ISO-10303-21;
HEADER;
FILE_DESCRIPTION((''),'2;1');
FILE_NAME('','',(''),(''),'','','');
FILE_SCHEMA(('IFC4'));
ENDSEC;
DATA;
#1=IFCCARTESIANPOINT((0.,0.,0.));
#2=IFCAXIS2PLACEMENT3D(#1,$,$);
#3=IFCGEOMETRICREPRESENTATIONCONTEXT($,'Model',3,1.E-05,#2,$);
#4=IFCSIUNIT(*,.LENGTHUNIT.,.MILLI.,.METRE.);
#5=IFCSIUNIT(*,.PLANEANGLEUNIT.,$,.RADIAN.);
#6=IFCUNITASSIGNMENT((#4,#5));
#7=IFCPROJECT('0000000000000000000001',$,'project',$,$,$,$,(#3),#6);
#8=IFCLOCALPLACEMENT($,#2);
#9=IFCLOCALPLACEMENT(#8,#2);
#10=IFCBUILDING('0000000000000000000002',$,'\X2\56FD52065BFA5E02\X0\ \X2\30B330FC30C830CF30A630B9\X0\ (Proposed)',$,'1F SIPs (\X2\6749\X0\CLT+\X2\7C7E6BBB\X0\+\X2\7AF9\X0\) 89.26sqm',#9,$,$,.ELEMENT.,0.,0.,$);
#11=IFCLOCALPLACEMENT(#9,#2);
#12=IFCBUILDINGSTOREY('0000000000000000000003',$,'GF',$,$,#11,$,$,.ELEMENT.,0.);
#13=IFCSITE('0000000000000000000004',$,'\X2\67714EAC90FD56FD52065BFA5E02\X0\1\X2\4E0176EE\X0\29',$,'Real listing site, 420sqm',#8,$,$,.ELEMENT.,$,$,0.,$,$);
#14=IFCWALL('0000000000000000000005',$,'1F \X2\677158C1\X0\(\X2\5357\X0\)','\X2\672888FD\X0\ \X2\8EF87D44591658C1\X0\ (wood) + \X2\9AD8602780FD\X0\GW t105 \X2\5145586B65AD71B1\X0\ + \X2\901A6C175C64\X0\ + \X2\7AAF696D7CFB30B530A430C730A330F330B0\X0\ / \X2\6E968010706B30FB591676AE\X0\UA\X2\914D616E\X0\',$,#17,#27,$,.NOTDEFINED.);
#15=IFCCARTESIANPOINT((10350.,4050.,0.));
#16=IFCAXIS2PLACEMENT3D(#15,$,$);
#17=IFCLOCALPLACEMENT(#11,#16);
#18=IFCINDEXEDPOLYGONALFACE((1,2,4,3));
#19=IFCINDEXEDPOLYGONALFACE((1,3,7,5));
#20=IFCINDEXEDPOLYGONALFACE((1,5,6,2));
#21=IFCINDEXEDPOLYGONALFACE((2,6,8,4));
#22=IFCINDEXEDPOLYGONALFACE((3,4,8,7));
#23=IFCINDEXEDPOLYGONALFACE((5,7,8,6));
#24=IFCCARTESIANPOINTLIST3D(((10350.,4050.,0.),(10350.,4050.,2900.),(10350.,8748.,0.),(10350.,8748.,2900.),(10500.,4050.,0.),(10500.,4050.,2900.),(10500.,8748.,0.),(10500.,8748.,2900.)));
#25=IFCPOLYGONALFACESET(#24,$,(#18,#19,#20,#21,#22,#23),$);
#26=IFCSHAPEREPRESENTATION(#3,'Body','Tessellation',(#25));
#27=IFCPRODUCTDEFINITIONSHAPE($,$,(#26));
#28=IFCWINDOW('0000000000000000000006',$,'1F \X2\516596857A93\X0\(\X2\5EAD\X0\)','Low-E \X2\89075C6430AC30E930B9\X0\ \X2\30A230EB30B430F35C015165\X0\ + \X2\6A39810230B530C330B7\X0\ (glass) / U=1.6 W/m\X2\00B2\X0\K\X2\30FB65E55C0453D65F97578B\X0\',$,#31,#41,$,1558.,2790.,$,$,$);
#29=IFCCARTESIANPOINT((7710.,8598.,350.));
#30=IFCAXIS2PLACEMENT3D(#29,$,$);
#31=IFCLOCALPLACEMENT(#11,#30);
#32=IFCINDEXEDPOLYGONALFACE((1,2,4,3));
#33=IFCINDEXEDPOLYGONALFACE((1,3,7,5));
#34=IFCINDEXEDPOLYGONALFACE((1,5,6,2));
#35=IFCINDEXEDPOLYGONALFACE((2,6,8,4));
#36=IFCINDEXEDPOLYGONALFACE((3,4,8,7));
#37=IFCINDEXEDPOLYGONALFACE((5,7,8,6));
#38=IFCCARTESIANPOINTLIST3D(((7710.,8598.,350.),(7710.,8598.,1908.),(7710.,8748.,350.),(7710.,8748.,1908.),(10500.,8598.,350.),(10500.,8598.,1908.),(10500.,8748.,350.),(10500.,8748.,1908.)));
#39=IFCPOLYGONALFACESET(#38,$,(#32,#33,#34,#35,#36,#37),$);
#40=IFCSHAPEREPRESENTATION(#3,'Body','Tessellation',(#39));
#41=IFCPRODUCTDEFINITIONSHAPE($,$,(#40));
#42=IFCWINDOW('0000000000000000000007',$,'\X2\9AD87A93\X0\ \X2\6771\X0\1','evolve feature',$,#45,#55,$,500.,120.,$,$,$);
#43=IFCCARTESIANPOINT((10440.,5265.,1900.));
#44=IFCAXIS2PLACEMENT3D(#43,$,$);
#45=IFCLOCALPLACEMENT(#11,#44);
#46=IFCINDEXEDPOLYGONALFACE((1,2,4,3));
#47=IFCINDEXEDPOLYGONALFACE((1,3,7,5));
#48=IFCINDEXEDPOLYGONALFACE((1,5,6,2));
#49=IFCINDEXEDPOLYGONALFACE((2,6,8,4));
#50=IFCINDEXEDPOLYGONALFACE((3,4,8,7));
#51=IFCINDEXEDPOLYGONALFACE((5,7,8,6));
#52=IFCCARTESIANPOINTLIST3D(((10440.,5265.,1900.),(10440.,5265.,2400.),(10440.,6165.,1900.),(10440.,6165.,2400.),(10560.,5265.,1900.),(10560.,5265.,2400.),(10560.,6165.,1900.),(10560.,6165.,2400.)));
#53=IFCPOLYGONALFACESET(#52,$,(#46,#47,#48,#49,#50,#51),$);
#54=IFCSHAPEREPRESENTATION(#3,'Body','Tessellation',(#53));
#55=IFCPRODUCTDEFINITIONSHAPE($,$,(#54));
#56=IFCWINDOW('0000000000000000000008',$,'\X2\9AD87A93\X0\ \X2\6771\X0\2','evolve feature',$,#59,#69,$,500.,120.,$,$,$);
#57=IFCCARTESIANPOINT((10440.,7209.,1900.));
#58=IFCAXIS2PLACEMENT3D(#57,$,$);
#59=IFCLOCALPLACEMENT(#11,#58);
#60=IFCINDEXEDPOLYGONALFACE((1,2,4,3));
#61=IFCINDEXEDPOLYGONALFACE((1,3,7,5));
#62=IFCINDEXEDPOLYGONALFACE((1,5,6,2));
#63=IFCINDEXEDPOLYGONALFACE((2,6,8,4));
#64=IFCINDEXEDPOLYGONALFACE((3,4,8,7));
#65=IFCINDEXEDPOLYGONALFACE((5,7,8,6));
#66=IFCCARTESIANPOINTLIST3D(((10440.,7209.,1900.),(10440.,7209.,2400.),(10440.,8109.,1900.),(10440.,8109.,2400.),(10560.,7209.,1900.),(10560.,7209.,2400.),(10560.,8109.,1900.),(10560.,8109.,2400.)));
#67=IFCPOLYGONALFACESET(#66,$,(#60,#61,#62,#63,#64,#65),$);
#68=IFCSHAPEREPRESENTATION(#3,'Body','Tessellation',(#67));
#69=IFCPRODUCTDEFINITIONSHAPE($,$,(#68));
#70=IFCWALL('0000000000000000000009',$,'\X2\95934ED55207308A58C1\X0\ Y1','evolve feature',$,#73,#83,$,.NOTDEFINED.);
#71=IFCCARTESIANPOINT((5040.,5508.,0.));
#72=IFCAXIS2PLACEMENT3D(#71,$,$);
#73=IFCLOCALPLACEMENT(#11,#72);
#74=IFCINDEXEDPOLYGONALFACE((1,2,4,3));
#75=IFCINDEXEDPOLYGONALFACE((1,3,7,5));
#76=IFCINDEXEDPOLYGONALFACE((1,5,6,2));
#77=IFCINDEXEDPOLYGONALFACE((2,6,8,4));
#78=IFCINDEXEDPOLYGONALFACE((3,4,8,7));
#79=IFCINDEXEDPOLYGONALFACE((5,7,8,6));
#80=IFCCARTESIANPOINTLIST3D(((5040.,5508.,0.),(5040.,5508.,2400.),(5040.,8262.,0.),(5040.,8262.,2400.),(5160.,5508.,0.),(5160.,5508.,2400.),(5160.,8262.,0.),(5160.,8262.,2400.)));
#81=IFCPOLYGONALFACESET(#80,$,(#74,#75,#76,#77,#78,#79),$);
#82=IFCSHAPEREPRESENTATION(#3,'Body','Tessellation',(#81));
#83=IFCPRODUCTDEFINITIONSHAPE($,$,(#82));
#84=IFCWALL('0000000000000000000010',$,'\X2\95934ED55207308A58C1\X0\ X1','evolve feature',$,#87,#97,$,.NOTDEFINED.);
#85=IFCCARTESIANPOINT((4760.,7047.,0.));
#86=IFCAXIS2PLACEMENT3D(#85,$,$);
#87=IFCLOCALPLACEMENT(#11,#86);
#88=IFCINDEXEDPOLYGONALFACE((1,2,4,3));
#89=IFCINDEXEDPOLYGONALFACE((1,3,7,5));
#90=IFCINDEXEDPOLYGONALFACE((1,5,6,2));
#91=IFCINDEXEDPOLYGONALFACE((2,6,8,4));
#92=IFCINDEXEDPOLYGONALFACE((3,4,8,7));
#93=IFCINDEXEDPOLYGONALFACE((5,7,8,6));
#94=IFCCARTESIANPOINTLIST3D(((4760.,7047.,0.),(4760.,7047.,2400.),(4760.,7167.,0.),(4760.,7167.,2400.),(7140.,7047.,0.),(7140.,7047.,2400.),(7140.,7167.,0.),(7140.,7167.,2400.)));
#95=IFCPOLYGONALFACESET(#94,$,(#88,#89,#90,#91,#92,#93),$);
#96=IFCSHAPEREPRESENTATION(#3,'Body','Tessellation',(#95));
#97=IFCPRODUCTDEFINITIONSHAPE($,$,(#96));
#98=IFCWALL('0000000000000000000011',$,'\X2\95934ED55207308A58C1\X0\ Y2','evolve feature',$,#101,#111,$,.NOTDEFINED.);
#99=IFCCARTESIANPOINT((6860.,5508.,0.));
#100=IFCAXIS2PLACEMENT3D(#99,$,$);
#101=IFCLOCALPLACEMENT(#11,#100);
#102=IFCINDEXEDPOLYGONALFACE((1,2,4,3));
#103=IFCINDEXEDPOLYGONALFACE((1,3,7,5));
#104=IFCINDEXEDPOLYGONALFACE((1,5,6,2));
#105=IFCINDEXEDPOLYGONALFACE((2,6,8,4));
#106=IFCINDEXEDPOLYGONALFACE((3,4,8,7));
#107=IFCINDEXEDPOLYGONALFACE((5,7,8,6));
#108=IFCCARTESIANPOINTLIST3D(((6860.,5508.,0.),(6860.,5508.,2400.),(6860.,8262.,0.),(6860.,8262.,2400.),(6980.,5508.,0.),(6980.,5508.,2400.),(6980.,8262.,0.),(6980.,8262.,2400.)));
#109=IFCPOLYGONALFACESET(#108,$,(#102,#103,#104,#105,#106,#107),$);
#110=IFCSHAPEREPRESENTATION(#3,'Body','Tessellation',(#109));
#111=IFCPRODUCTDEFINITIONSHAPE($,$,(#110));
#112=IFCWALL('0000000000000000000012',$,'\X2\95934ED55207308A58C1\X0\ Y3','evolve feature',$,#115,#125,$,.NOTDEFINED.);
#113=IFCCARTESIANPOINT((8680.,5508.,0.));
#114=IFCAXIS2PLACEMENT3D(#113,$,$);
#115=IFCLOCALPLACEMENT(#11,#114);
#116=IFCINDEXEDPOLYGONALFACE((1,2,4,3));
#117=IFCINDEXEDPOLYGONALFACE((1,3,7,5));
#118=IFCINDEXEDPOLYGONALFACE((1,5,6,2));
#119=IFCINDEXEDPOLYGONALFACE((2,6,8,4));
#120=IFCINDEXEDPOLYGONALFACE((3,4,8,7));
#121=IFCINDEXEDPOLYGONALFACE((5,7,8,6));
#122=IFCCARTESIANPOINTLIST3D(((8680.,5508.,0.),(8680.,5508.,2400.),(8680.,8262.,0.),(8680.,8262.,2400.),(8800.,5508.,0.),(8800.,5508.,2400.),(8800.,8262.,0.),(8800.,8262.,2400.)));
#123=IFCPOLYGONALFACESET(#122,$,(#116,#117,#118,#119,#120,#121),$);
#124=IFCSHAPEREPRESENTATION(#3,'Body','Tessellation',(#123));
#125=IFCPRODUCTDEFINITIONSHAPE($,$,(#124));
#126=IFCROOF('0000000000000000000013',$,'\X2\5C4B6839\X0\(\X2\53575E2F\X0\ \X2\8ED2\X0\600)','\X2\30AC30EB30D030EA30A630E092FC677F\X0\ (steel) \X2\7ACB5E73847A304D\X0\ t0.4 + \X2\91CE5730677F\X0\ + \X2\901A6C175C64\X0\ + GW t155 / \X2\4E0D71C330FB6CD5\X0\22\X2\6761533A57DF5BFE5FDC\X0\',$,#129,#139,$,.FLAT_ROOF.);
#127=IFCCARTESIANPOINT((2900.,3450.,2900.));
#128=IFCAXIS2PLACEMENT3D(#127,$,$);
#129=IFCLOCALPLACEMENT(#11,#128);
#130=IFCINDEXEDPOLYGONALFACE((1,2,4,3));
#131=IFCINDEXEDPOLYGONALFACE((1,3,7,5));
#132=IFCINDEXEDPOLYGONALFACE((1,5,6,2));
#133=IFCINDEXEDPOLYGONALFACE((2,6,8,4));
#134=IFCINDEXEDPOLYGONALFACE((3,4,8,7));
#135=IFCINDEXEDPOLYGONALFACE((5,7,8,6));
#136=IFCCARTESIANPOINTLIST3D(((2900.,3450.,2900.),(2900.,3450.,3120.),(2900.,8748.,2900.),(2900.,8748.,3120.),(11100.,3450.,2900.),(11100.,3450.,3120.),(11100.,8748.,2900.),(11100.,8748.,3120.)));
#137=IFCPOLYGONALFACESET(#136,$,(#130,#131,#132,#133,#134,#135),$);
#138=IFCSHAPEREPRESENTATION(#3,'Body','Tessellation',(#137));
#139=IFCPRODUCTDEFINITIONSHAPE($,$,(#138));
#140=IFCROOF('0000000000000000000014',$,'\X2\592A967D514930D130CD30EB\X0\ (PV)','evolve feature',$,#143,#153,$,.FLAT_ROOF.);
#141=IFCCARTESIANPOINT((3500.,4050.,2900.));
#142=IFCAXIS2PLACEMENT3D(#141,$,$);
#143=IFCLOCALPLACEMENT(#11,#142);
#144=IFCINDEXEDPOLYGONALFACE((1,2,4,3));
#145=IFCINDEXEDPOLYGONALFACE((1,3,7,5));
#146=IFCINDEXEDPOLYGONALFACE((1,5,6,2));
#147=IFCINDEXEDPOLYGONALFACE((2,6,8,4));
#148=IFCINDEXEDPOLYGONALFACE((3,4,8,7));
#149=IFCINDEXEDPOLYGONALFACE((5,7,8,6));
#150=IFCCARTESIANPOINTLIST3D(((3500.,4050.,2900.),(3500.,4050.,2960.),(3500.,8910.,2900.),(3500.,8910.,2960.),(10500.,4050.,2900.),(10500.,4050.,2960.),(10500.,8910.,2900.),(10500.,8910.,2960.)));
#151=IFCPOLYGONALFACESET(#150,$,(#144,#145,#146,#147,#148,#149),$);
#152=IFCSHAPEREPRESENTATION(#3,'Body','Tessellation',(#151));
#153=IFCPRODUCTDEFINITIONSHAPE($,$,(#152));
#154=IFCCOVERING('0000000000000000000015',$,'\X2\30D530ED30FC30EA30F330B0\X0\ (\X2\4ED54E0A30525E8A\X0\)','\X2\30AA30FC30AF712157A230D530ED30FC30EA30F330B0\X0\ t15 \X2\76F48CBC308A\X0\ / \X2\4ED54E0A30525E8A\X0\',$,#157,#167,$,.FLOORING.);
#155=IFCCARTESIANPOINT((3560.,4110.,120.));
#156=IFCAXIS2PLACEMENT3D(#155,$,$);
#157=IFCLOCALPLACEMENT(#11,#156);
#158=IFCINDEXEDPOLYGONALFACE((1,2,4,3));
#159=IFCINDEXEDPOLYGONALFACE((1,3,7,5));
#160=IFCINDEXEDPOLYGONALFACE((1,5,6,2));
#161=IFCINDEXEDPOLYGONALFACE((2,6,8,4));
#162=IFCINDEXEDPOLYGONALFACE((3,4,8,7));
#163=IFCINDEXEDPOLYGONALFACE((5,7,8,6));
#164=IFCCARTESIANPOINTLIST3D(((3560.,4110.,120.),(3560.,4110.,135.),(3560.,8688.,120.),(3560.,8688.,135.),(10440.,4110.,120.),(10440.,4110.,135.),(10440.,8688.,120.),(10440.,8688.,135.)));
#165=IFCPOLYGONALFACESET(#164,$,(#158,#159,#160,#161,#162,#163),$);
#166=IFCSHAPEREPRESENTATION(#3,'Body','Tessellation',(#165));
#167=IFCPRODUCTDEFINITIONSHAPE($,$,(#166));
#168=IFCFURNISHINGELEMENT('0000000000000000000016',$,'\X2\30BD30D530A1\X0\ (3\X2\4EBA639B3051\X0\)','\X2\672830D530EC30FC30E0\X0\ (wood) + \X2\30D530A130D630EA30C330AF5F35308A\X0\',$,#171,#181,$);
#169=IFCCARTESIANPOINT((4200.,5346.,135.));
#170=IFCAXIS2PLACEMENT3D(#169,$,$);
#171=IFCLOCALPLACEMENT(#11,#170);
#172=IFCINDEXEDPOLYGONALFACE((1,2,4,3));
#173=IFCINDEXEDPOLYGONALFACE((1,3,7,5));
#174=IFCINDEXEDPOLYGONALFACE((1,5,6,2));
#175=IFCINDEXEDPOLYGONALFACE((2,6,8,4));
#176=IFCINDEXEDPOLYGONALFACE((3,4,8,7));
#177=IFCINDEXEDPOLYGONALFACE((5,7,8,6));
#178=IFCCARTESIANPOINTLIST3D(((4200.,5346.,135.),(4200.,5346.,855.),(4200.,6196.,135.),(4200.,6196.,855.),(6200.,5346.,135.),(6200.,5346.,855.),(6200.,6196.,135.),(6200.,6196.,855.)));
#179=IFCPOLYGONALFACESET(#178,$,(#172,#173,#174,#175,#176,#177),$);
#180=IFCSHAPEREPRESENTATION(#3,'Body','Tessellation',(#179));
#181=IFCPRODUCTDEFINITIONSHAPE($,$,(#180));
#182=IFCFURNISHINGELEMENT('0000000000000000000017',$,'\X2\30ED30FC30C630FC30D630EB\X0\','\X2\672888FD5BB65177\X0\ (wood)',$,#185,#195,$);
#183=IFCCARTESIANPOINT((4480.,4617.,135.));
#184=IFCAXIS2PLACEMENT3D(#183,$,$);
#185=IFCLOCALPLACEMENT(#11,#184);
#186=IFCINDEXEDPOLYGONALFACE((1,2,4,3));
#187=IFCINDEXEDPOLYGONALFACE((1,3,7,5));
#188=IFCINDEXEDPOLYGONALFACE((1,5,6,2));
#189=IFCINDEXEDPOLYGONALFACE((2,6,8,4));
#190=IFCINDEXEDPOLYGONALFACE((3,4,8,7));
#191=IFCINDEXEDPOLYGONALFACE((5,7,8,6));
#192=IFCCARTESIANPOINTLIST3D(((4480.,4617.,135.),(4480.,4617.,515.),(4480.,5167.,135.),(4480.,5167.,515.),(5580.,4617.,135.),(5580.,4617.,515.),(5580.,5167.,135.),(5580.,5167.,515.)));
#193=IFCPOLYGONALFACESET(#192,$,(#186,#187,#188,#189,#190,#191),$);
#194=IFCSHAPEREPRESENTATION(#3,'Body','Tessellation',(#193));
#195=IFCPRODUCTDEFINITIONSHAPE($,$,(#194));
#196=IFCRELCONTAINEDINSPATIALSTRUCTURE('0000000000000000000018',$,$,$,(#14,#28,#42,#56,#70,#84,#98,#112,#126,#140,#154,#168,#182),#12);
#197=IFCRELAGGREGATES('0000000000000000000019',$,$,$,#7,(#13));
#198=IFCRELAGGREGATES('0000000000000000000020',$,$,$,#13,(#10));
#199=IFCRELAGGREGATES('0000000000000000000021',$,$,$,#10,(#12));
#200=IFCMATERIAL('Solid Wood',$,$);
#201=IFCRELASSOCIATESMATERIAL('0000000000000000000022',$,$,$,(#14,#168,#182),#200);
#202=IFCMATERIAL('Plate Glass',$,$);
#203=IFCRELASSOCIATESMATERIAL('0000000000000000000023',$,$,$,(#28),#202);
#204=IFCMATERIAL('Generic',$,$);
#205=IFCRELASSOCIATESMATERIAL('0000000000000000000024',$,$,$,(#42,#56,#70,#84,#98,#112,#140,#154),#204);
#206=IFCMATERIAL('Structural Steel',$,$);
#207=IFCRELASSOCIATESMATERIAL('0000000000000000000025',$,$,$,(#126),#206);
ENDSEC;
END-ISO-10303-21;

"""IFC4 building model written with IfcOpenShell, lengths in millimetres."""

from ifc_helpers import new_model, si_unit, frame, frame_2d, origin, place, context, project, spatial, rectangle, extrude, material, element, fill, save


model = new_model("IFC4")

# Units and contexts
model_context = context("Model", 3, precision=1e-05, world=origin())
ifc_project = project(units=[si_unit("LENGTHUNIT", "METRE", prefix="MILLI"), si_unit("PLANEANGLEUNIT", "RADIAN")], contexts=[model_context])

# Site, building, storey
site_placement = place(None, origin())
site = spatial("IfcSite", under=ifc_project, at=site_placement, Name="東京都国分寺市1丁目29", ObjectType="Real listing site, 420sqm", CompositionType="ELEMENT", RefElevation=0.0)
building_placement = place(site_placement, origin())
building = spatial("IfcBuilding", under=site, at=building_placement, Name="国分寺市 コートハウス (Proposed)", ObjectType="1F SIPs (杉CLT+籾殻+竹) 89.26sqm", CompositionType="ELEMENT", ElevationOfRefHeight=0.0, ElevationOfTerrain=0.0)
storey_placement = place(building_placement, origin())
storey = spatial("IfcBuildingStorey", under=building, at=storey_placement, Name="GF", CompositionType="ELEMENT", Elevation=0.0)

# Shared definitions
ifc_material_1 = material(Name="Solid Wood")
ifc_material_2 = material(Name="Generic")

# Shared definitions
ifc_material_3 = material(Name="Plate Glass")

# Wall, openings, windows
wall_1_placement = place(storey_placement, frame((10350.0, 4050.0, 0.0)))
wall_1 = element("IfcWall", 1, at=wall_1_placement, inside=storey, material=ifc_material_1, Name="1F 東壁(南)", Description="木製 軸組外壁 (wood) + 高性能GW t105 充填断熱 + 通気層 + 窯業系サイディング / 準耐火・外皮UA配慮", PredefinedType="NOTDEFINED", context=model_context, shape_type="SweptSolid", body=[
    extrude(rectangle(XDim=150.0, YDim=4698.0, at=frame_2d((75.0, 2349.0))), frame((10350.0, 4050.0, 0.0)), (0.0, 0.0, 1.0), 2900.0),
])
opening_1_placement = place(storey_placement, frame((7710.0, 8598.0, 350.0)))
opening_1 = element("IfcOpeningElement", 2, at=opening_1_placement, cuts=wall_1, PredefinedType="NOTDEFINED", context=model_context, shape_type="SweptSolid", body=[
    extrude(rectangle(XDim=2790.0, YDim=150.0, at=frame_2d((1395.0, 75.0))), frame((7710.0, 8598.0, 350.0)), (0.0, 0.0, 1.0), 1558.0),
])
opening_2_placement = place(storey_placement, frame((10440.0, 5265.0, 1900.0)))
opening_2 = element("IfcOpeningElement", 3, at=opening_2_placement, cuts=wall_1, PredefinedType="NOTDEFINED", context=model_context, shape_type="SweptSolid", body=[
    extrude(rectangle(XDim=120.0, YDim=900.0, at=frame_2d((60.0, 450.0))), frame((10440.0, 5265.0, 1900.0)), (0.0, 0.0, 1.0), 500.0),
])
opening_3_placement = place(storey_placement, frame((10440.0, 7209.0, 1900.0)))
opening_3 = element("IfcOpeningElement", 4, at=opening_3_placement, cuts=wall_1, PredefinedType="NOTDEFINED", context=model_context, shape_type="SweptSolid", body=[
    extrude(rectangle(XDim=120.0, YDim=900.0, at=frame_2d((60.0, 450.0))), frame((10440.0, 7209.0, 1900.0)), (0.0, 0.0, 1.0), 500.0),
])
window_1_placement = place(storey_placement, frame((7710.0, 8598.0, 350.0)))
window_1 = element("IfcWindow", 5, at=window_1_placement, inside=storey, material=ifc_material_3, Name="1F 入隅窓(庭)", Description="Low-E 複層ガラス アルゴン封入 + 樹脂サッシ (glass) / U=1.6 W/m²K・日射取得型", OverallHeight=1558.0, OverallWidth=2790.0, context=model_context, shape_type="SweptSolid", body=[
    extrude(rectangle(XDim=2790.0, YDim=150.0, at=frame_2d((1395.0, 75.0))), frame((7710.0, 8598.0, 350.0)), (0.0, 0.0, 1.0), 1558.0),
])
fill(opening_1, window_1)
window_2_placement = place(storey_placement, frame((10440.0, 5265.0, 1900.0)))
window_2 = element("IfcWindow", 6, at=window_2_placement, inside=storey, material=ifc_material_2, Name="高窓 東1", Description="evolve feature", OverallHeight=500.0, OverallWidth=120.0, context=model_context, shape_type="SweptSolid", body=[
    extrude(rectangle(XDim=120.0, YDim=900.0, at=frame_2d((60.0, 450.0))), frame((10440.0, 5265.0, 1900.0)), (0.0, 0.0, 1.0), 500.0),
])
fill(opening_2, window_2)
window_3_placement = place(storey_placement, frame((10440.0, 7209.0, 1900.0)))
window_3 = element("IfcWindow", 7, at=window_3_placement, inside=storey, material=ifc_material_2, Name="高窓 東2", Description="evolve feature", OverallHeight=500.0, OverallWidth=120.0, context=model_context, shape_type="SweptSolid", body=[
    extrude(rectangle(XDim=120.0, YDim=900.0, at=frame_2d((60.0, 450.0))), frame((10440.0, 7209.0, 1900.0)), (0.0, 0.0, 1.0), 500.0),
])
fill(opening_3, window_3)

# Walls
wall_2_placement = place(storey_placement, frame((5040.0, 5508.0, 0.0)))
element("IfcWall", 8, at=wall_2_placement, inside=storey, material=ifc_material_2, Name="間仕切り壁 Y1", Description="evolve feature", PredefinedType="NOTDEFINED", context=model_context, shape_type="SweptSolid", body=[
    extrude(rectangle(XDim=120.0, YDim=2754.0, at=frame_2d((60.0, 1377.0))), frame((5040.0, 5508.0, 0.0)), (0.0, 0.0, 1.0), 2400.0),
])
wall_3_placement = place(storey_placement, frame((4760.0, 7047.0, 0.0)))
element("IfcWall", 9, at=wall_3_placement, inside=storey, material=ifc_material_2, Name="間仕切り壁 X1", Description="evolve feature", PredefinedType="NOTDEFINED", context=model_context, shape_type="SweptSolid", body=[
    extrude(rectangle(XDim=2380.0, YDim=120.0, at=frame_2d((1190.0, 60.0))), frame((4760.0, 7047.0, 0.0)), (0.0, 0.0, 1.0), 2400.0),
])
wall_4_placement = place(storey_placement, frame((6860.0, 5508.0, 0.0)))
element("IfcWall", 10, at=wall_4_placement, inside=storey, material=ifc_material_2, Name="間仕切り壁 Y2", Description="evolve feature", PredefinedType="NOTDEFINED", context=model_context, shape_type="SweptSolid", body=[
    extrude(rectangle(XDim=120.0, YDim=2754.0, at=frame_2d((60.0, 1377.0))), frame((6860.0, 5508.0, 0.0)), (0.0, 0.0, 1.0), 2400.0),
])
wall_5_placement = place(storey_placement, frame((8680.0, 5508.0, 0.0)))
element("IfcWall", 11, at=wall_5_placement, inside=storey, material=ifc_material_2, Name="間仕切り壁 Y3", Description="evolve feature", PredefinedType="NOTDEFINED", context=model_context, shape_type="SweptSolid", body=[
    extrude(rectangle(XDim=120.0, YDim=2754.0, at=frame_2d((60.0, 1377.0))), frame((8680.0, 5508.0, 0.0)), (0.0, 0.0, 1.0), 2400.0),
])

# Roofs
ifc_material_4 = material(Name="Structural Steel")
roof_1_placement = place(storey_placement, frame((2900.0, 3450.0, 2900.0)))
element("IfcRoof", 12, at=roof_1_placement, inside=storey, material=ifc_material_4, Name="屋根(南帯 軒600)", Description="ガルバリウム鋼板 (steel) 立平葺き t0.4 + 野地板 + 通気層 + GW t155 / 不燃・法22条区域対応", PredefinedType="FLAT_ROOF", context=model_context, shape_type="SweptSolid", body=[
    extrude(rectangle(XDim=8200.0, YDim=5298.0, at=frame_2d((4100.0, 2649.0))), frame((2900.0, 3450.0, 2900.0)), (0.0, 0.0, 1.0), 220.0),
])
roof_2_placement = place(storey_placement, frame((3500.0, 4050.0, 2900.0)))
element("IfcRoof", 13, at=roof_2_placement, inside=storey, material=ifc_material_2, Name="太陽光パネル (PV)", Description="evolve feature", PredefinedType="FLAT_ROOF", context=model_context, shape_type="SweptSolid", body=[
    extrude(rectangle(XDim=7000.0, YDim=4860.0, at=frame_2d((3500.0, 2430.0))), frame((3500.0, 4050.0, 2900.0)), (0.0, 0.0, 1.0), 60.0),
])

# Covering
covering_placement = place(storey_placement, frame((3560.0, 4110.0, 120.0)))
element("IfcCovering", 14, at=covering_placement, inside=storey, material=ifc_material_2, Name="フローリング (仕上げ床)", Description="オーク無垢フローリング t15 直貼り / 仕上げ床", PredefinedType="FLOORING", context=model_context, shape_type="SweptSolid", body=[
    extrude(rectangle(XDim=6880.0, YDim=4578.0, at=frame_2d((3440.0, 2289.0))), frame((3560.0, 4110.0, 120.0)), (0.0, 0.0, 1.0), 15.0),
])

# Furnishing elements
furnishing_1_placement = place(storey_placement, frame((4200.0, 5346.0, 135.0)))
element("IfcFurnishingElement", 15, at=furnishing_1_placement, inside=storey, material=ifc_material_1, Name="ソファ (3人掛け)", Description="木フレーム (wood) + ファブリック張り", context=model_context, shape_type="SweptSolid", body=[
    extrude(rectangle(XDim=2000.0, YDim=850.0, at=frame_2d((1000.0, 425.0))), frame((4200.0, 5346.0, 135.0)), (0.0, 0.0, 1.0), 720.0),
])
furnishing_2_placement = place(storey_placement, frame((4480.0, 4617.0, 135.0)))
element("IfcFurnishingElement", 16, at=furnishing_2_placement, inside=storey, material=ifc_material_1, Name="ローテーブル", Description="木製家具 (wood)", context=model_context, shape_type="SweptSolid", body=[
    extrude(rectangle(XDim=1100.0, YDim=550.0, at=frame_2d((550.0, 275.0))), frame((4480.0, 4617.0, 135.0)), (0.0, 0.0, 1.0), 380.0),
])

save(model, "model.ifc")
